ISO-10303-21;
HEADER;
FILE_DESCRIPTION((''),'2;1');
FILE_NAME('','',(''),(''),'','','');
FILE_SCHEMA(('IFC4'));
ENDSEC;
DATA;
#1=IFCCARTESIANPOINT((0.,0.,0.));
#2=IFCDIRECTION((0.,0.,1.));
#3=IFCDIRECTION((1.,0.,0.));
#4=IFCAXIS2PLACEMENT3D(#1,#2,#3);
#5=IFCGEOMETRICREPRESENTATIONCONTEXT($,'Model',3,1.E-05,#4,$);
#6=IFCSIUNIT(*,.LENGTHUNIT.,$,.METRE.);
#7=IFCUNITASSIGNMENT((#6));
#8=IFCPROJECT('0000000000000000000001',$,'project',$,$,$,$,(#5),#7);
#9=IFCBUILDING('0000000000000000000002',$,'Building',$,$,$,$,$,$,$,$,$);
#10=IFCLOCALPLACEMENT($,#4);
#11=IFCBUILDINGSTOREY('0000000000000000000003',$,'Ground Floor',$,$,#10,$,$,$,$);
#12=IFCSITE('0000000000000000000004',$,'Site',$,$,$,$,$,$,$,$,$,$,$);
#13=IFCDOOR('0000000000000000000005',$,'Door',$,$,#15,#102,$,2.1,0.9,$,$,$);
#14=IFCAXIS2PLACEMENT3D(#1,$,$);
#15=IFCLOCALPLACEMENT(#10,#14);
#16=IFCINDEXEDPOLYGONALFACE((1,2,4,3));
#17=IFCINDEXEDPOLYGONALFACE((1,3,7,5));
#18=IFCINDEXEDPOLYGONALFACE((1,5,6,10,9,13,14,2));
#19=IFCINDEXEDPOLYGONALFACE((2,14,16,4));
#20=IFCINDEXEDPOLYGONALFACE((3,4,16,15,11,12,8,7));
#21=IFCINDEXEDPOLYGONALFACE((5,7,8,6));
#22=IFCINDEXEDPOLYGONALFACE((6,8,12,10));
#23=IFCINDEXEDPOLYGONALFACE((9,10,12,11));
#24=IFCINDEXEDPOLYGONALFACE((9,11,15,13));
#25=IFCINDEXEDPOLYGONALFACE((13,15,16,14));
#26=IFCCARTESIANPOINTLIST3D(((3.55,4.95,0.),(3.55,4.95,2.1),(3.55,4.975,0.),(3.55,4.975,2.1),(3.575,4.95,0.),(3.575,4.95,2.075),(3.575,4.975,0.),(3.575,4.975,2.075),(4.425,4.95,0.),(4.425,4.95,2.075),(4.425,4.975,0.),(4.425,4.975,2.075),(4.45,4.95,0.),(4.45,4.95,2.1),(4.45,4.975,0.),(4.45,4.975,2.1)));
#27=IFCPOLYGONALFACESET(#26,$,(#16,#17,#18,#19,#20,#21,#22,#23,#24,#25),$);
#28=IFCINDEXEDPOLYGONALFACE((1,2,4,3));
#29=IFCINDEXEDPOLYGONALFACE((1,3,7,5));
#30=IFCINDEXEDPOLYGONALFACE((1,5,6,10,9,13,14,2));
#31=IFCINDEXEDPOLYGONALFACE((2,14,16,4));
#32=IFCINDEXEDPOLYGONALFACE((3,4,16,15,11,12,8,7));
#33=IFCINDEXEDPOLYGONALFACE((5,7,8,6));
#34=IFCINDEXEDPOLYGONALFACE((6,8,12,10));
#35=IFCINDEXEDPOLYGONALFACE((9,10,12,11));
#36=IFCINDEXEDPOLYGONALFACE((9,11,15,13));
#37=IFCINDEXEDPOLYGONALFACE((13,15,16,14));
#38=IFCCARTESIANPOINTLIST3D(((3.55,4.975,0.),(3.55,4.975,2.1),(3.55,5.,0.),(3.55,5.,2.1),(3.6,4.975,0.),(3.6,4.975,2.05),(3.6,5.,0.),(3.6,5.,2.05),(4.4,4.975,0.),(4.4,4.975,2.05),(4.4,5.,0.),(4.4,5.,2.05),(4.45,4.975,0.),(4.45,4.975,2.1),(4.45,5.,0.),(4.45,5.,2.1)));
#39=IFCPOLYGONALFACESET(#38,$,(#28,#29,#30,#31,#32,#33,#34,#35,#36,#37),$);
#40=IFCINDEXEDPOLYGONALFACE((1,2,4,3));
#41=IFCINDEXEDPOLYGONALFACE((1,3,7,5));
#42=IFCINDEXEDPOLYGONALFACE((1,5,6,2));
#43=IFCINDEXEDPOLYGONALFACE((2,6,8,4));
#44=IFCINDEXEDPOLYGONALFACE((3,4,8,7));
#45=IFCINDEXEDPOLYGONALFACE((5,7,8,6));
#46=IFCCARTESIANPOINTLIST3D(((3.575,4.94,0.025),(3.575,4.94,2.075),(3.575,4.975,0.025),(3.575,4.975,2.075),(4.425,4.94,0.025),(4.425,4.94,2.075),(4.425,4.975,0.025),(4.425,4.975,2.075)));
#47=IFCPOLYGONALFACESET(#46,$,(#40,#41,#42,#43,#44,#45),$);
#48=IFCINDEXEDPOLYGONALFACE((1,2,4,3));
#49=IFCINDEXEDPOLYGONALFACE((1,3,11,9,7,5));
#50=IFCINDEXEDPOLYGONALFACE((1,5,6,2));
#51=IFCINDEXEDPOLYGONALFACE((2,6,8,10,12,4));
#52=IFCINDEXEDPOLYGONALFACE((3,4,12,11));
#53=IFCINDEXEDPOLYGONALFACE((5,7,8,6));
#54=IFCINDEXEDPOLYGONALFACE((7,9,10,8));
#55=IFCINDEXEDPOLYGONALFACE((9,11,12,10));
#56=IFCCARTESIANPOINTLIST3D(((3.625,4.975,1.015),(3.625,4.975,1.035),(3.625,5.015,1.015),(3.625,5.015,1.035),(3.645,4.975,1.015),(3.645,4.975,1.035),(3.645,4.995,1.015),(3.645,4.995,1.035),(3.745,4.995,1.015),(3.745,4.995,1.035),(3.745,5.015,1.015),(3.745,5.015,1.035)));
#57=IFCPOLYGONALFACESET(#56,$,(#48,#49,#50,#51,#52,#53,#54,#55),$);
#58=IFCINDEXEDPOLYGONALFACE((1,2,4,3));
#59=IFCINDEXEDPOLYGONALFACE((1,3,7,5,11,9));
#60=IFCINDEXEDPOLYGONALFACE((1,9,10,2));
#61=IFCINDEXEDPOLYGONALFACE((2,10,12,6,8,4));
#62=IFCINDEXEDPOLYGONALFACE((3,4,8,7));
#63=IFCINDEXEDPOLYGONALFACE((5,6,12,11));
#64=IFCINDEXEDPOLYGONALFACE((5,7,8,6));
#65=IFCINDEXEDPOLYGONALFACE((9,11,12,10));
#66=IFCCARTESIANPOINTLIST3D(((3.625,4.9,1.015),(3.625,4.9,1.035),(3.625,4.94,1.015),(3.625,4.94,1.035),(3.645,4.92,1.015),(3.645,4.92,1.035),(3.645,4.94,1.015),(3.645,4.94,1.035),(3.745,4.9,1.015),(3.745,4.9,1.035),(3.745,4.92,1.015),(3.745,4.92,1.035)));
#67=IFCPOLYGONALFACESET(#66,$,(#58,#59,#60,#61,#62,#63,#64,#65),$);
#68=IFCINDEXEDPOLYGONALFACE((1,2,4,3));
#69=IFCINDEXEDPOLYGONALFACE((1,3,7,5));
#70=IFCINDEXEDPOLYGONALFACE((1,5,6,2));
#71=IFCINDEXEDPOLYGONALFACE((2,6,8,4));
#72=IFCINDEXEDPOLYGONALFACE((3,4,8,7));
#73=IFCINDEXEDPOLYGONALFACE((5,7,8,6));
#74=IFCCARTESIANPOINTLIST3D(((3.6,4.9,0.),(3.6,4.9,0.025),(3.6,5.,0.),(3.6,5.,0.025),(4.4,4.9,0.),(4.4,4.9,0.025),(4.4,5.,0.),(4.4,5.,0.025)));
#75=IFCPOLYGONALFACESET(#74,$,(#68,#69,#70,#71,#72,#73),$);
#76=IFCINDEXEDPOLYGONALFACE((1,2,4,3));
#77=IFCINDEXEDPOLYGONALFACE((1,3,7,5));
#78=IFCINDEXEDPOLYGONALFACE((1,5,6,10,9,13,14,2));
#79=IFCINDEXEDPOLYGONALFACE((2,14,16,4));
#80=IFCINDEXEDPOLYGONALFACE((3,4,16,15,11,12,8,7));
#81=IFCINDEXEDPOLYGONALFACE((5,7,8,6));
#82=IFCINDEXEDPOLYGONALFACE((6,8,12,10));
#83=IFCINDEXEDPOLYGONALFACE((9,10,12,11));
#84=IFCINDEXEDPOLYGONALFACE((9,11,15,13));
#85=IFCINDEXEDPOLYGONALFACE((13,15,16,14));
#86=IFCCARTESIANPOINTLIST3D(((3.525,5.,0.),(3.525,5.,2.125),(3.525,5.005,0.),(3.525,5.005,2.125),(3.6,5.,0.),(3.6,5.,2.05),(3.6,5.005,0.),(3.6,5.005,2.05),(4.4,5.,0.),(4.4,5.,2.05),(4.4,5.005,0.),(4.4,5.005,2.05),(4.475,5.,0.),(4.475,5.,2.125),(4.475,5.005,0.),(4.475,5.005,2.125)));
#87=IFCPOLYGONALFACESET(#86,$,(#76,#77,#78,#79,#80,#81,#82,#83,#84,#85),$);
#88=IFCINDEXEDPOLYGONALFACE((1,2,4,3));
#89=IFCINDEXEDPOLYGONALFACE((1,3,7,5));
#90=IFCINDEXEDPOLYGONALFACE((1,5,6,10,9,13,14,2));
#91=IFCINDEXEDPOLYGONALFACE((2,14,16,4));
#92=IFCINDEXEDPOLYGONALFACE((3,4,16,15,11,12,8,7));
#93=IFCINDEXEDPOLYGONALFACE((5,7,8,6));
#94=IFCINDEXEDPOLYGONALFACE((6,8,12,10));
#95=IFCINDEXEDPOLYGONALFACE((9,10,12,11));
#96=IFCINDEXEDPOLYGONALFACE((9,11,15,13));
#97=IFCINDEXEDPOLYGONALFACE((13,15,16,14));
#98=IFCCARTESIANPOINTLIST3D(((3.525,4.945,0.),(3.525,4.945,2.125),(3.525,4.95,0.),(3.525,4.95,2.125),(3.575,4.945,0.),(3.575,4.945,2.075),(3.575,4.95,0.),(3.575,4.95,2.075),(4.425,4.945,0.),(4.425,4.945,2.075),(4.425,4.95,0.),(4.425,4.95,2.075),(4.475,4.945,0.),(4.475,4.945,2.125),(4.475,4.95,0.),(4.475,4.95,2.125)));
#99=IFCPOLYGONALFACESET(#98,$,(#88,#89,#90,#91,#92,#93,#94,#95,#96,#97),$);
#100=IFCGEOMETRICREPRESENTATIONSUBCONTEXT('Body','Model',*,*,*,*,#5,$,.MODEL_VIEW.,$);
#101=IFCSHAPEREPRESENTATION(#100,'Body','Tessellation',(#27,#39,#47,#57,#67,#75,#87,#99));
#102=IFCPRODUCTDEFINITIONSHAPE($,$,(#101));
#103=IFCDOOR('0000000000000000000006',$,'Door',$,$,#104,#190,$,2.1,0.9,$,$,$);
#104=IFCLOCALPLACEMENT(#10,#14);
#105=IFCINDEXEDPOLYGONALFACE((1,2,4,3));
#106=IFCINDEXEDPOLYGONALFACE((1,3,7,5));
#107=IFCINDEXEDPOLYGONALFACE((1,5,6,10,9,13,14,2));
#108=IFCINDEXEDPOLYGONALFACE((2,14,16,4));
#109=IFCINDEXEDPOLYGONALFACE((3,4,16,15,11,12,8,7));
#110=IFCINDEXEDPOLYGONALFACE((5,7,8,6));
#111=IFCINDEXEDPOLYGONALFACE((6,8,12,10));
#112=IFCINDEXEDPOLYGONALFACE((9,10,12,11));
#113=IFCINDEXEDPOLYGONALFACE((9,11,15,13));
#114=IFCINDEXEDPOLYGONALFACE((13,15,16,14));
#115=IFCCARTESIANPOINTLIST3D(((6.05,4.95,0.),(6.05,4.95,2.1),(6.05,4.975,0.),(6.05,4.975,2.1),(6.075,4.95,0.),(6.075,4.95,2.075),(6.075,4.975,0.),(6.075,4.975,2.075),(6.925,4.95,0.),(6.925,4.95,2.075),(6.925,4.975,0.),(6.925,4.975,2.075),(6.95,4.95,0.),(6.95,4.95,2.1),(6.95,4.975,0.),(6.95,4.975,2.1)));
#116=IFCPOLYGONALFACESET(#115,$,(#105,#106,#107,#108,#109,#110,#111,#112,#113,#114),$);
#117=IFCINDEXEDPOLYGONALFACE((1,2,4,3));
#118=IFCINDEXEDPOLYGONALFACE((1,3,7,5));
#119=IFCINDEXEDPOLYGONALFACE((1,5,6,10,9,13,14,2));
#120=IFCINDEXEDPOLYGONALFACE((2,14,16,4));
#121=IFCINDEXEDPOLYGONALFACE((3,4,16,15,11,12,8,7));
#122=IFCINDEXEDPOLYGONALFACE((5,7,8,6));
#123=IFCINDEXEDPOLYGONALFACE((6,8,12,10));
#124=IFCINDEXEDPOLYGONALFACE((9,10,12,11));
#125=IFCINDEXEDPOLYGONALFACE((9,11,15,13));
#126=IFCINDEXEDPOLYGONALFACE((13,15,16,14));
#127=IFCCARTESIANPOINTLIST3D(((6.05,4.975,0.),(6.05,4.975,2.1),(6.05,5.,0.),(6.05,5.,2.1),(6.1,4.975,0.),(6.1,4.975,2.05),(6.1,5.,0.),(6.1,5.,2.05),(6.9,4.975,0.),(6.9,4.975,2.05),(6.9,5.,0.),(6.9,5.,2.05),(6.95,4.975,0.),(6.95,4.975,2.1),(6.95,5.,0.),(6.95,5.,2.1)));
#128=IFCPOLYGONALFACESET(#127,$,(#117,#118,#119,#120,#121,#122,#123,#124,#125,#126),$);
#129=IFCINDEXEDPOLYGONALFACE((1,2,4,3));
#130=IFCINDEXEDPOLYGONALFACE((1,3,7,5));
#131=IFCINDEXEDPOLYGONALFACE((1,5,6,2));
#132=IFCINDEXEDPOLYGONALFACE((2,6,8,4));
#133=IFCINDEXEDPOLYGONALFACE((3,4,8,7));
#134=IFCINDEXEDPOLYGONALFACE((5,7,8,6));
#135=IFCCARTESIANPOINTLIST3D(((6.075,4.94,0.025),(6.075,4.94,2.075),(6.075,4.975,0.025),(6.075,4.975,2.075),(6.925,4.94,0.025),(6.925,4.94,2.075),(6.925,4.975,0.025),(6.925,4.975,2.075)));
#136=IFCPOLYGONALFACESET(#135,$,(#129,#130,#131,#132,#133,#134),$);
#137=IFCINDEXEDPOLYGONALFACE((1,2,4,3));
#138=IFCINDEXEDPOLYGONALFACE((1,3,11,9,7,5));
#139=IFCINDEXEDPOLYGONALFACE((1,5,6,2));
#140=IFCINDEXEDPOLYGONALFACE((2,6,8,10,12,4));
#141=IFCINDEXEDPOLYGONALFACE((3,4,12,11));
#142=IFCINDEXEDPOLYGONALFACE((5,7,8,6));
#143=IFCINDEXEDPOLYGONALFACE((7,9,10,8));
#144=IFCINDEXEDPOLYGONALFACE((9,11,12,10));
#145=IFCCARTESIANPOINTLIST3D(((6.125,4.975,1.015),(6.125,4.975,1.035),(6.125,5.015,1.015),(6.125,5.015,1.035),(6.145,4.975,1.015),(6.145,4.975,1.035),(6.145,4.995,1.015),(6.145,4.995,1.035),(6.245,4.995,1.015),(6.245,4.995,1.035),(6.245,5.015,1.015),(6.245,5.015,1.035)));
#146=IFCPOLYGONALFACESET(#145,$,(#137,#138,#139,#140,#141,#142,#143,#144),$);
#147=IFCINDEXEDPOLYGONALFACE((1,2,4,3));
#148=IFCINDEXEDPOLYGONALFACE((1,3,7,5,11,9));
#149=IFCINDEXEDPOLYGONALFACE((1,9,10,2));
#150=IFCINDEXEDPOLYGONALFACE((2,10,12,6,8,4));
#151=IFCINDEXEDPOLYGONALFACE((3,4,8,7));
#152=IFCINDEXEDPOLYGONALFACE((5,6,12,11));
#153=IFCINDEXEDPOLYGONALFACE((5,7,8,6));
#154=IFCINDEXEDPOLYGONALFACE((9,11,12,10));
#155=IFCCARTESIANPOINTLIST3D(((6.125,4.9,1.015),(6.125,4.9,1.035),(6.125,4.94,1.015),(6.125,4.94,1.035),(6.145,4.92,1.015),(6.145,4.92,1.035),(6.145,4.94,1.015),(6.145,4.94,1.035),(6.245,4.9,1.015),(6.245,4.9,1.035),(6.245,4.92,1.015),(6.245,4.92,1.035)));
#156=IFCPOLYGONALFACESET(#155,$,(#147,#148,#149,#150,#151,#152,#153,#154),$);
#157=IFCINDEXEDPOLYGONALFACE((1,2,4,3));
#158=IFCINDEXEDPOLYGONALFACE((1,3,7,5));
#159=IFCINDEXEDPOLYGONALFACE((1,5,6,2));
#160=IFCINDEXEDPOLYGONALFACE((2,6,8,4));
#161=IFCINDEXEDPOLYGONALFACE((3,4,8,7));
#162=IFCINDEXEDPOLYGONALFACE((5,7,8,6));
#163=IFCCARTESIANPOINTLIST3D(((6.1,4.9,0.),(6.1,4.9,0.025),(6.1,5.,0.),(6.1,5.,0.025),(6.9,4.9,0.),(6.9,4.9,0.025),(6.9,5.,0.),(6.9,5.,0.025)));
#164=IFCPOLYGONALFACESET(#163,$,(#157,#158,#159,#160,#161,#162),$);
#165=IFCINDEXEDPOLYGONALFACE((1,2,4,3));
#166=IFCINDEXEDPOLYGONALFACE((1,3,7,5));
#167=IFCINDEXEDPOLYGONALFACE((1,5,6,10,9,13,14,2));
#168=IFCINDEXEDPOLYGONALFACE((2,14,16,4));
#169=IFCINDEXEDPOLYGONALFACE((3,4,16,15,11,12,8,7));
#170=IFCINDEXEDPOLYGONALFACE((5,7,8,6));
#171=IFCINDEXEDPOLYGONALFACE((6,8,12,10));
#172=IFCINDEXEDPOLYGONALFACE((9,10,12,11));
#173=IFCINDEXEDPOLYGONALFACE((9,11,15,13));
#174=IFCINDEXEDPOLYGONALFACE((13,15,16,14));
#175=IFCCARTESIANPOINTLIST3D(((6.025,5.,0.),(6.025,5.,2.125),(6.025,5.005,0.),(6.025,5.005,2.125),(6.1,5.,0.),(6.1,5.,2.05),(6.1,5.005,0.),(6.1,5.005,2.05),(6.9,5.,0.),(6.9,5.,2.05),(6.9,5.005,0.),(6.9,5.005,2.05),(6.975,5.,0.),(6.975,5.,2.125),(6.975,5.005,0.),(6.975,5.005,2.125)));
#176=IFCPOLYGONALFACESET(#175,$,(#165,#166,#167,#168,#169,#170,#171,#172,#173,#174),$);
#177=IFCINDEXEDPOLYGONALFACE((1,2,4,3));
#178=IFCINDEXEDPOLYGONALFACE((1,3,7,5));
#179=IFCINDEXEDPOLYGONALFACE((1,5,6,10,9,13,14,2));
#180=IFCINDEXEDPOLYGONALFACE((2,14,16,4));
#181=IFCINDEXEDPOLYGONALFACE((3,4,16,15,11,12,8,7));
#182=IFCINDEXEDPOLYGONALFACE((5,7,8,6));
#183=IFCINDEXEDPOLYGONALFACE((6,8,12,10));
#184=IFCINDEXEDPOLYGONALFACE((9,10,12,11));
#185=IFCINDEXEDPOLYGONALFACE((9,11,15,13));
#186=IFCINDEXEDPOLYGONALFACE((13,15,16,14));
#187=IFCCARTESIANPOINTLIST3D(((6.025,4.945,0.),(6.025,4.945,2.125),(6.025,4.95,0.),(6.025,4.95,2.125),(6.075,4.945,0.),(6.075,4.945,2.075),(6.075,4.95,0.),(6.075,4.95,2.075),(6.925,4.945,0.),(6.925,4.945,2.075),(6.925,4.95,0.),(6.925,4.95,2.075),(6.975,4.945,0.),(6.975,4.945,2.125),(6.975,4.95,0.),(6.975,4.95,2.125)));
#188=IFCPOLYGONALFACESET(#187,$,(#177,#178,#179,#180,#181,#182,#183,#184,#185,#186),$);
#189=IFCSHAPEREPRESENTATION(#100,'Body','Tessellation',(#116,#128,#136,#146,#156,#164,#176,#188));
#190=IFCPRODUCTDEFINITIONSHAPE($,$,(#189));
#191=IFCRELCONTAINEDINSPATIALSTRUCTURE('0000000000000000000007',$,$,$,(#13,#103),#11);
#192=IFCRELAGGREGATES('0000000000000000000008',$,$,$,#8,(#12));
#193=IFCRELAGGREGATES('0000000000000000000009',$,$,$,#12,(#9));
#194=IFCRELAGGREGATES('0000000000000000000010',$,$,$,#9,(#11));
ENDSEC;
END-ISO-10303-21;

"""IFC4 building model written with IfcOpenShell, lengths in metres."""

from ifc_helpers import new_model, si_unit, frame, origin_with_axes, place, context, subcontext, project, spatial, line, indexed_curve, outline, extrude, element, save


model = new_model("IFC4")

# Units and contexts
model_context = context("Model", 3, precision=1e-05, world=origin_with_axes())
body_context = subcontext(model_context, "Body", "Model", "MODEL_VIEW")
ifc_project = project(units=[si_unit("LENGTHUNIT", "METRE")], contexts=[model_context])

# Site, building, storey
site = spatial("IfcSite", under=ifc_project, Name="Site")
building = spatial("IfcBuilding", under=site, Name="Building")
storey_placement = place(None, origin_with_axes())
storey = spatial("IfcBuildingStorey", under=building, at=storey_placement, Name="Ground Floor")

# Doors
door_1_placement = place(storey_placement, frame((4.45, 5.0, 0.0), z_axis=(0.0, 0.0, 1.0), x_axis=(-1.0, 0.0, 0.0)))
element("IfcDoor", 1, at=door_1_placement, inside=storey, Name="Door", OverallHeight=2.1, OverallWidth=0.9, context=body_context, shape_type="SweptSolid", body=[
    extrude(outline(indexed_curve([(0.0, 0.0), (0.0, 2.1), (0.9, 2.1), (0.9, 0.0), (0.875, 0.0), (0.875, 2.075), (0.025, 2.075), (0.025, 0.0)], segments=[line(1, 2, 3, 4, 5, 6, 7, 8, 1)])), frame((0.0, 0.025, 0.0), z_axis=(0.0, -1.0, 0.0), x_axis=(1.0, 0.0, 0.0)), (0.0, 0.0, -1.0), 0.025),
    extrude(outline(indexed_curve([(0.0, 0.0), (0.0, 2.1), (0.9, 2.1), (0.9, 0.0), (0.85, 0.0), (0.85, 2.05), (0.05, 2.05), (0.05, 0.0)], segments=[line(1, 2, 3, 4, 5, 6, 7, 8, 1)])), frame((0.0, 0.0, 0.0), z_axis=(0.0, -1.0, 0.0), x_axis=(1.0, 0.0, 0.0)), (0.0, 0.0, -1.0), 0.025),
    extrude(outline(indexed_curve([(0.0, 0.0), (0.85, 0.0), (0.85, 0.035), (0.0, 0.035)], segments=[line(1, 2, 3, 4, 1)])), frame((0.025, 0.025, 0.025), z_axis=(0.0, 0.0, 1.0), x_axis=(1.0, 0.0, 0.0)), (0.0, 0.0, 1.0), 2.05),
    extrude(outline(indexed_curve([(0.0, 0.0), (0.0, -0.04), (-0.12, -0.04), (-0.12, -0.02), (-0.02, -0.02), (-0.02, 0.0)], segments=[line(1, 2, 3, 4, 5, 6, 1)])), frame((0.825, 0.025, 1.015), z_axis=(0.0, 0.0, 1.0), x_axis=(1.0, 0.0, 0.0)), (0.0, 0.0, 1.0), 0.02),
    extrude(outline(indexed_curve([(0.0, 0.0), (0.0, 0.04), (-0.12, 0.04), (-0.12, 0.02), (-0.02, 0.02), (-0.02, 0.0)], segments=[line(1, 2, 3, 4, 5, 6, 1)])), frame((0.825, 0.06, 1.015), z_axis=(0.0, 0.0, 1.0), x_axis=(1.0, 0.0, 0.0)), (0.0, 0.0, 1.0), 0.02),
    extrude(outline(indexed_curve([(0.0, 0.0), (0.8, 0.0), (0.8, 0.1), (0.0, 0.1)], segments=[line(1, 2, 3, 4, 1)])), frame((0.05, 0.0, 0.0), z_axis=(0.0, 0.0, 1.0), x_axis=(1.0, 0.0, 0.0)), (0.0, 0.0, 1.0), 0.025),
    extrude(outline(indexed_curve([(0.0, 0.0), (0.0, 2.125), (0.95, 2.125), (0.95, 0.0), (0.875, 0.0), (0.875, 2.05), (0.075, 2.05), (0.075, 0.0)], segments=[line(1, 2, 3, 4, 5, 6, 7, 8, 1)])), frame((-0.025, -0.005, 0.0), z_axis=(0.0, -1.0, 0.0), x_axis=(1.0, 0.0, 0.0)), (0.0, 0.0, -1.0), 0.005),
    extrude(outline(indexed_curve([(0.0, 0.0), (0.0, 2.125), (0.95, 2.125), (0.95, 0.0), (0.9, 0.0), (0.9, 2.075), (0.05, 2.075), (0.05, 0.0)], segments=[line(1, 2, 3, 4, 5, 6, 7, 8, 1)])), frame((-0.025, 0.05, 0.0), z_axis=(0.0, -1.0, 0.0), x_axis=(1.0, 0.0, 0.0)), (0.0, 0.0, -1.0), 0.005),
])
door_2_placement = place(storey_placement, frame((6.95, 5.0, 0.0), z_axis=(0.0, 0.0, 1.0), x_axis=(-1.0, 0.0, 0.0)))
element("IfcDoor", 2, at=door_2_placement, inside=storey, Name="Door", OverallHeight=2.1, OverallWidth=0.9, context=body_context, shape_type="SweptSolid", body=[
    extrude(outline(indexed_curve([(0.0, 0.0), (0.0, 2.1), (0.9, 2.1), (0.9, 0.0), (0.875, 0.0), (0.875, 2.075), (0.025, 2.075), (0.025, 0.0)], segments=[line(1, 2, 3, 4, 5, 6, 7, 8, 1)])), frame((0.0, 0.025, 0.0), z_axis=(0.0, -1.0, 0.0), x_axis=(1.0, 0.0, 0.0)), (0.0, 0.0, -1.0), 0.025),
    extrude(outline(indexed_curve([(0.0, 0.0), (0.0, 2.1), (0.9, 2.1), (0.9, 0.0), (0.85, 0.0), (0.85, 2.05), (0.05, 2.05), (0.05, 0.0)], segments=[line(1, 2, 3, 4, 5, 6, 7, 8, 1)])), frame((0.0, 0.0, 0.0), z_axis=(0.0, -1.0, 0.0), x_axis=(1.0, 0.0, 0.0)), (0.0, 0.0, -1.0), 0.025),
    extrude(outline(indexed_curve([(0.0, 0.0), (0.85, 0.0), (0.85, 0.035), (0.0, 0.035)], segments=[line(1, 2, 3, 4, 1)])), frame((0.025, 0.025, 0.025), z_axis=(0.0, 0.0, 1.0), x_axis=(1.0, 0.0, 0.0)), (0.0, 0.0, 1.0), 2.05),
    extrude(outline(indexed_curve([(0.0, 0.0), (0.0, -0.04), (-0.12, -0.04), (-0.12, -0.02), (-0.02, -0.02), (-0.02, 0.0)], segments=[line(1, 2, 3, 4, 5, 6, 1)])), frame((0.825, 0.025, 1.015), z_axis=(0.0, 0.0, 1.0), x_axis=(1.0, 0.0, 0.0)), (0.0, 0.0, 1.0), 0.02),
    extrude(outline(indexed_curve([(0.0, 0.0), (0.0, 0.04), (-0.12, 0.04), (-0.12, 0.02), (-0.02, 0.02), (-0.02, 0.0)], segments=[line(1, 2, 3, 4, 5, 6, 1)])), frame((0.825, 0.06, 1.015), z_axis=(0.0, 0.0, 1.0), x_axis=(1.0, 0.0, 0.0)), (0.0, 0.0, 1.0), 0.02),
    extrude(outline(indexed_curve([(0.0, 0.0), (0.8, 0.0), (0.8, 0.1), (0.0, 0.1)], segments=[line(1, 2, 3, 4, 1)])), frame((0.05, 0.0, 0.0), z_axis=(0.0, 0.0, 1.0), x_axis=(1.0, 0.0, 0.0)), (0.0, 0.0, 1.0), 0.025),
    extrude(outline(indexed_curve([(0.0, 0.0), (0.0, 2.125), (0.95, 2.125), (0.95, 0.0), (0.875, 0.0), (0.875, 2.05), (0.075, 2.05), (0.075, 0.0)], segments=[line(1, 2, 3, 4, 5, 6, 7, 8, 1)])), frame((-0.025, -0.005, 0.0), z_axis=(0.0, -1.0, 0.0), x_axis=(1.0, 0.0, 0.0)), (0.0, 0.0, -1.0), 0.005),
    extrude(outline(indexed_curve([(0.0, 0.0), (0.0, 2.125), (0.95, 2.125), (0.95, 0.0), (0.9, 0.0), (0.9, 2.075), (0.05, 2.075), (0.05, 0.0)], segments=[line(1, 2, 3, 4, 5, 6, 7, 8, 1)])), frame((-0.025, 0.05, 0.0), z_axis=(0.0, -1.0, 0.0), x_axis=(1.0, 0.0, 0.0)), (0.0, 0.0, -1.0), 0.005),
])

save(model, "model.ifc")
